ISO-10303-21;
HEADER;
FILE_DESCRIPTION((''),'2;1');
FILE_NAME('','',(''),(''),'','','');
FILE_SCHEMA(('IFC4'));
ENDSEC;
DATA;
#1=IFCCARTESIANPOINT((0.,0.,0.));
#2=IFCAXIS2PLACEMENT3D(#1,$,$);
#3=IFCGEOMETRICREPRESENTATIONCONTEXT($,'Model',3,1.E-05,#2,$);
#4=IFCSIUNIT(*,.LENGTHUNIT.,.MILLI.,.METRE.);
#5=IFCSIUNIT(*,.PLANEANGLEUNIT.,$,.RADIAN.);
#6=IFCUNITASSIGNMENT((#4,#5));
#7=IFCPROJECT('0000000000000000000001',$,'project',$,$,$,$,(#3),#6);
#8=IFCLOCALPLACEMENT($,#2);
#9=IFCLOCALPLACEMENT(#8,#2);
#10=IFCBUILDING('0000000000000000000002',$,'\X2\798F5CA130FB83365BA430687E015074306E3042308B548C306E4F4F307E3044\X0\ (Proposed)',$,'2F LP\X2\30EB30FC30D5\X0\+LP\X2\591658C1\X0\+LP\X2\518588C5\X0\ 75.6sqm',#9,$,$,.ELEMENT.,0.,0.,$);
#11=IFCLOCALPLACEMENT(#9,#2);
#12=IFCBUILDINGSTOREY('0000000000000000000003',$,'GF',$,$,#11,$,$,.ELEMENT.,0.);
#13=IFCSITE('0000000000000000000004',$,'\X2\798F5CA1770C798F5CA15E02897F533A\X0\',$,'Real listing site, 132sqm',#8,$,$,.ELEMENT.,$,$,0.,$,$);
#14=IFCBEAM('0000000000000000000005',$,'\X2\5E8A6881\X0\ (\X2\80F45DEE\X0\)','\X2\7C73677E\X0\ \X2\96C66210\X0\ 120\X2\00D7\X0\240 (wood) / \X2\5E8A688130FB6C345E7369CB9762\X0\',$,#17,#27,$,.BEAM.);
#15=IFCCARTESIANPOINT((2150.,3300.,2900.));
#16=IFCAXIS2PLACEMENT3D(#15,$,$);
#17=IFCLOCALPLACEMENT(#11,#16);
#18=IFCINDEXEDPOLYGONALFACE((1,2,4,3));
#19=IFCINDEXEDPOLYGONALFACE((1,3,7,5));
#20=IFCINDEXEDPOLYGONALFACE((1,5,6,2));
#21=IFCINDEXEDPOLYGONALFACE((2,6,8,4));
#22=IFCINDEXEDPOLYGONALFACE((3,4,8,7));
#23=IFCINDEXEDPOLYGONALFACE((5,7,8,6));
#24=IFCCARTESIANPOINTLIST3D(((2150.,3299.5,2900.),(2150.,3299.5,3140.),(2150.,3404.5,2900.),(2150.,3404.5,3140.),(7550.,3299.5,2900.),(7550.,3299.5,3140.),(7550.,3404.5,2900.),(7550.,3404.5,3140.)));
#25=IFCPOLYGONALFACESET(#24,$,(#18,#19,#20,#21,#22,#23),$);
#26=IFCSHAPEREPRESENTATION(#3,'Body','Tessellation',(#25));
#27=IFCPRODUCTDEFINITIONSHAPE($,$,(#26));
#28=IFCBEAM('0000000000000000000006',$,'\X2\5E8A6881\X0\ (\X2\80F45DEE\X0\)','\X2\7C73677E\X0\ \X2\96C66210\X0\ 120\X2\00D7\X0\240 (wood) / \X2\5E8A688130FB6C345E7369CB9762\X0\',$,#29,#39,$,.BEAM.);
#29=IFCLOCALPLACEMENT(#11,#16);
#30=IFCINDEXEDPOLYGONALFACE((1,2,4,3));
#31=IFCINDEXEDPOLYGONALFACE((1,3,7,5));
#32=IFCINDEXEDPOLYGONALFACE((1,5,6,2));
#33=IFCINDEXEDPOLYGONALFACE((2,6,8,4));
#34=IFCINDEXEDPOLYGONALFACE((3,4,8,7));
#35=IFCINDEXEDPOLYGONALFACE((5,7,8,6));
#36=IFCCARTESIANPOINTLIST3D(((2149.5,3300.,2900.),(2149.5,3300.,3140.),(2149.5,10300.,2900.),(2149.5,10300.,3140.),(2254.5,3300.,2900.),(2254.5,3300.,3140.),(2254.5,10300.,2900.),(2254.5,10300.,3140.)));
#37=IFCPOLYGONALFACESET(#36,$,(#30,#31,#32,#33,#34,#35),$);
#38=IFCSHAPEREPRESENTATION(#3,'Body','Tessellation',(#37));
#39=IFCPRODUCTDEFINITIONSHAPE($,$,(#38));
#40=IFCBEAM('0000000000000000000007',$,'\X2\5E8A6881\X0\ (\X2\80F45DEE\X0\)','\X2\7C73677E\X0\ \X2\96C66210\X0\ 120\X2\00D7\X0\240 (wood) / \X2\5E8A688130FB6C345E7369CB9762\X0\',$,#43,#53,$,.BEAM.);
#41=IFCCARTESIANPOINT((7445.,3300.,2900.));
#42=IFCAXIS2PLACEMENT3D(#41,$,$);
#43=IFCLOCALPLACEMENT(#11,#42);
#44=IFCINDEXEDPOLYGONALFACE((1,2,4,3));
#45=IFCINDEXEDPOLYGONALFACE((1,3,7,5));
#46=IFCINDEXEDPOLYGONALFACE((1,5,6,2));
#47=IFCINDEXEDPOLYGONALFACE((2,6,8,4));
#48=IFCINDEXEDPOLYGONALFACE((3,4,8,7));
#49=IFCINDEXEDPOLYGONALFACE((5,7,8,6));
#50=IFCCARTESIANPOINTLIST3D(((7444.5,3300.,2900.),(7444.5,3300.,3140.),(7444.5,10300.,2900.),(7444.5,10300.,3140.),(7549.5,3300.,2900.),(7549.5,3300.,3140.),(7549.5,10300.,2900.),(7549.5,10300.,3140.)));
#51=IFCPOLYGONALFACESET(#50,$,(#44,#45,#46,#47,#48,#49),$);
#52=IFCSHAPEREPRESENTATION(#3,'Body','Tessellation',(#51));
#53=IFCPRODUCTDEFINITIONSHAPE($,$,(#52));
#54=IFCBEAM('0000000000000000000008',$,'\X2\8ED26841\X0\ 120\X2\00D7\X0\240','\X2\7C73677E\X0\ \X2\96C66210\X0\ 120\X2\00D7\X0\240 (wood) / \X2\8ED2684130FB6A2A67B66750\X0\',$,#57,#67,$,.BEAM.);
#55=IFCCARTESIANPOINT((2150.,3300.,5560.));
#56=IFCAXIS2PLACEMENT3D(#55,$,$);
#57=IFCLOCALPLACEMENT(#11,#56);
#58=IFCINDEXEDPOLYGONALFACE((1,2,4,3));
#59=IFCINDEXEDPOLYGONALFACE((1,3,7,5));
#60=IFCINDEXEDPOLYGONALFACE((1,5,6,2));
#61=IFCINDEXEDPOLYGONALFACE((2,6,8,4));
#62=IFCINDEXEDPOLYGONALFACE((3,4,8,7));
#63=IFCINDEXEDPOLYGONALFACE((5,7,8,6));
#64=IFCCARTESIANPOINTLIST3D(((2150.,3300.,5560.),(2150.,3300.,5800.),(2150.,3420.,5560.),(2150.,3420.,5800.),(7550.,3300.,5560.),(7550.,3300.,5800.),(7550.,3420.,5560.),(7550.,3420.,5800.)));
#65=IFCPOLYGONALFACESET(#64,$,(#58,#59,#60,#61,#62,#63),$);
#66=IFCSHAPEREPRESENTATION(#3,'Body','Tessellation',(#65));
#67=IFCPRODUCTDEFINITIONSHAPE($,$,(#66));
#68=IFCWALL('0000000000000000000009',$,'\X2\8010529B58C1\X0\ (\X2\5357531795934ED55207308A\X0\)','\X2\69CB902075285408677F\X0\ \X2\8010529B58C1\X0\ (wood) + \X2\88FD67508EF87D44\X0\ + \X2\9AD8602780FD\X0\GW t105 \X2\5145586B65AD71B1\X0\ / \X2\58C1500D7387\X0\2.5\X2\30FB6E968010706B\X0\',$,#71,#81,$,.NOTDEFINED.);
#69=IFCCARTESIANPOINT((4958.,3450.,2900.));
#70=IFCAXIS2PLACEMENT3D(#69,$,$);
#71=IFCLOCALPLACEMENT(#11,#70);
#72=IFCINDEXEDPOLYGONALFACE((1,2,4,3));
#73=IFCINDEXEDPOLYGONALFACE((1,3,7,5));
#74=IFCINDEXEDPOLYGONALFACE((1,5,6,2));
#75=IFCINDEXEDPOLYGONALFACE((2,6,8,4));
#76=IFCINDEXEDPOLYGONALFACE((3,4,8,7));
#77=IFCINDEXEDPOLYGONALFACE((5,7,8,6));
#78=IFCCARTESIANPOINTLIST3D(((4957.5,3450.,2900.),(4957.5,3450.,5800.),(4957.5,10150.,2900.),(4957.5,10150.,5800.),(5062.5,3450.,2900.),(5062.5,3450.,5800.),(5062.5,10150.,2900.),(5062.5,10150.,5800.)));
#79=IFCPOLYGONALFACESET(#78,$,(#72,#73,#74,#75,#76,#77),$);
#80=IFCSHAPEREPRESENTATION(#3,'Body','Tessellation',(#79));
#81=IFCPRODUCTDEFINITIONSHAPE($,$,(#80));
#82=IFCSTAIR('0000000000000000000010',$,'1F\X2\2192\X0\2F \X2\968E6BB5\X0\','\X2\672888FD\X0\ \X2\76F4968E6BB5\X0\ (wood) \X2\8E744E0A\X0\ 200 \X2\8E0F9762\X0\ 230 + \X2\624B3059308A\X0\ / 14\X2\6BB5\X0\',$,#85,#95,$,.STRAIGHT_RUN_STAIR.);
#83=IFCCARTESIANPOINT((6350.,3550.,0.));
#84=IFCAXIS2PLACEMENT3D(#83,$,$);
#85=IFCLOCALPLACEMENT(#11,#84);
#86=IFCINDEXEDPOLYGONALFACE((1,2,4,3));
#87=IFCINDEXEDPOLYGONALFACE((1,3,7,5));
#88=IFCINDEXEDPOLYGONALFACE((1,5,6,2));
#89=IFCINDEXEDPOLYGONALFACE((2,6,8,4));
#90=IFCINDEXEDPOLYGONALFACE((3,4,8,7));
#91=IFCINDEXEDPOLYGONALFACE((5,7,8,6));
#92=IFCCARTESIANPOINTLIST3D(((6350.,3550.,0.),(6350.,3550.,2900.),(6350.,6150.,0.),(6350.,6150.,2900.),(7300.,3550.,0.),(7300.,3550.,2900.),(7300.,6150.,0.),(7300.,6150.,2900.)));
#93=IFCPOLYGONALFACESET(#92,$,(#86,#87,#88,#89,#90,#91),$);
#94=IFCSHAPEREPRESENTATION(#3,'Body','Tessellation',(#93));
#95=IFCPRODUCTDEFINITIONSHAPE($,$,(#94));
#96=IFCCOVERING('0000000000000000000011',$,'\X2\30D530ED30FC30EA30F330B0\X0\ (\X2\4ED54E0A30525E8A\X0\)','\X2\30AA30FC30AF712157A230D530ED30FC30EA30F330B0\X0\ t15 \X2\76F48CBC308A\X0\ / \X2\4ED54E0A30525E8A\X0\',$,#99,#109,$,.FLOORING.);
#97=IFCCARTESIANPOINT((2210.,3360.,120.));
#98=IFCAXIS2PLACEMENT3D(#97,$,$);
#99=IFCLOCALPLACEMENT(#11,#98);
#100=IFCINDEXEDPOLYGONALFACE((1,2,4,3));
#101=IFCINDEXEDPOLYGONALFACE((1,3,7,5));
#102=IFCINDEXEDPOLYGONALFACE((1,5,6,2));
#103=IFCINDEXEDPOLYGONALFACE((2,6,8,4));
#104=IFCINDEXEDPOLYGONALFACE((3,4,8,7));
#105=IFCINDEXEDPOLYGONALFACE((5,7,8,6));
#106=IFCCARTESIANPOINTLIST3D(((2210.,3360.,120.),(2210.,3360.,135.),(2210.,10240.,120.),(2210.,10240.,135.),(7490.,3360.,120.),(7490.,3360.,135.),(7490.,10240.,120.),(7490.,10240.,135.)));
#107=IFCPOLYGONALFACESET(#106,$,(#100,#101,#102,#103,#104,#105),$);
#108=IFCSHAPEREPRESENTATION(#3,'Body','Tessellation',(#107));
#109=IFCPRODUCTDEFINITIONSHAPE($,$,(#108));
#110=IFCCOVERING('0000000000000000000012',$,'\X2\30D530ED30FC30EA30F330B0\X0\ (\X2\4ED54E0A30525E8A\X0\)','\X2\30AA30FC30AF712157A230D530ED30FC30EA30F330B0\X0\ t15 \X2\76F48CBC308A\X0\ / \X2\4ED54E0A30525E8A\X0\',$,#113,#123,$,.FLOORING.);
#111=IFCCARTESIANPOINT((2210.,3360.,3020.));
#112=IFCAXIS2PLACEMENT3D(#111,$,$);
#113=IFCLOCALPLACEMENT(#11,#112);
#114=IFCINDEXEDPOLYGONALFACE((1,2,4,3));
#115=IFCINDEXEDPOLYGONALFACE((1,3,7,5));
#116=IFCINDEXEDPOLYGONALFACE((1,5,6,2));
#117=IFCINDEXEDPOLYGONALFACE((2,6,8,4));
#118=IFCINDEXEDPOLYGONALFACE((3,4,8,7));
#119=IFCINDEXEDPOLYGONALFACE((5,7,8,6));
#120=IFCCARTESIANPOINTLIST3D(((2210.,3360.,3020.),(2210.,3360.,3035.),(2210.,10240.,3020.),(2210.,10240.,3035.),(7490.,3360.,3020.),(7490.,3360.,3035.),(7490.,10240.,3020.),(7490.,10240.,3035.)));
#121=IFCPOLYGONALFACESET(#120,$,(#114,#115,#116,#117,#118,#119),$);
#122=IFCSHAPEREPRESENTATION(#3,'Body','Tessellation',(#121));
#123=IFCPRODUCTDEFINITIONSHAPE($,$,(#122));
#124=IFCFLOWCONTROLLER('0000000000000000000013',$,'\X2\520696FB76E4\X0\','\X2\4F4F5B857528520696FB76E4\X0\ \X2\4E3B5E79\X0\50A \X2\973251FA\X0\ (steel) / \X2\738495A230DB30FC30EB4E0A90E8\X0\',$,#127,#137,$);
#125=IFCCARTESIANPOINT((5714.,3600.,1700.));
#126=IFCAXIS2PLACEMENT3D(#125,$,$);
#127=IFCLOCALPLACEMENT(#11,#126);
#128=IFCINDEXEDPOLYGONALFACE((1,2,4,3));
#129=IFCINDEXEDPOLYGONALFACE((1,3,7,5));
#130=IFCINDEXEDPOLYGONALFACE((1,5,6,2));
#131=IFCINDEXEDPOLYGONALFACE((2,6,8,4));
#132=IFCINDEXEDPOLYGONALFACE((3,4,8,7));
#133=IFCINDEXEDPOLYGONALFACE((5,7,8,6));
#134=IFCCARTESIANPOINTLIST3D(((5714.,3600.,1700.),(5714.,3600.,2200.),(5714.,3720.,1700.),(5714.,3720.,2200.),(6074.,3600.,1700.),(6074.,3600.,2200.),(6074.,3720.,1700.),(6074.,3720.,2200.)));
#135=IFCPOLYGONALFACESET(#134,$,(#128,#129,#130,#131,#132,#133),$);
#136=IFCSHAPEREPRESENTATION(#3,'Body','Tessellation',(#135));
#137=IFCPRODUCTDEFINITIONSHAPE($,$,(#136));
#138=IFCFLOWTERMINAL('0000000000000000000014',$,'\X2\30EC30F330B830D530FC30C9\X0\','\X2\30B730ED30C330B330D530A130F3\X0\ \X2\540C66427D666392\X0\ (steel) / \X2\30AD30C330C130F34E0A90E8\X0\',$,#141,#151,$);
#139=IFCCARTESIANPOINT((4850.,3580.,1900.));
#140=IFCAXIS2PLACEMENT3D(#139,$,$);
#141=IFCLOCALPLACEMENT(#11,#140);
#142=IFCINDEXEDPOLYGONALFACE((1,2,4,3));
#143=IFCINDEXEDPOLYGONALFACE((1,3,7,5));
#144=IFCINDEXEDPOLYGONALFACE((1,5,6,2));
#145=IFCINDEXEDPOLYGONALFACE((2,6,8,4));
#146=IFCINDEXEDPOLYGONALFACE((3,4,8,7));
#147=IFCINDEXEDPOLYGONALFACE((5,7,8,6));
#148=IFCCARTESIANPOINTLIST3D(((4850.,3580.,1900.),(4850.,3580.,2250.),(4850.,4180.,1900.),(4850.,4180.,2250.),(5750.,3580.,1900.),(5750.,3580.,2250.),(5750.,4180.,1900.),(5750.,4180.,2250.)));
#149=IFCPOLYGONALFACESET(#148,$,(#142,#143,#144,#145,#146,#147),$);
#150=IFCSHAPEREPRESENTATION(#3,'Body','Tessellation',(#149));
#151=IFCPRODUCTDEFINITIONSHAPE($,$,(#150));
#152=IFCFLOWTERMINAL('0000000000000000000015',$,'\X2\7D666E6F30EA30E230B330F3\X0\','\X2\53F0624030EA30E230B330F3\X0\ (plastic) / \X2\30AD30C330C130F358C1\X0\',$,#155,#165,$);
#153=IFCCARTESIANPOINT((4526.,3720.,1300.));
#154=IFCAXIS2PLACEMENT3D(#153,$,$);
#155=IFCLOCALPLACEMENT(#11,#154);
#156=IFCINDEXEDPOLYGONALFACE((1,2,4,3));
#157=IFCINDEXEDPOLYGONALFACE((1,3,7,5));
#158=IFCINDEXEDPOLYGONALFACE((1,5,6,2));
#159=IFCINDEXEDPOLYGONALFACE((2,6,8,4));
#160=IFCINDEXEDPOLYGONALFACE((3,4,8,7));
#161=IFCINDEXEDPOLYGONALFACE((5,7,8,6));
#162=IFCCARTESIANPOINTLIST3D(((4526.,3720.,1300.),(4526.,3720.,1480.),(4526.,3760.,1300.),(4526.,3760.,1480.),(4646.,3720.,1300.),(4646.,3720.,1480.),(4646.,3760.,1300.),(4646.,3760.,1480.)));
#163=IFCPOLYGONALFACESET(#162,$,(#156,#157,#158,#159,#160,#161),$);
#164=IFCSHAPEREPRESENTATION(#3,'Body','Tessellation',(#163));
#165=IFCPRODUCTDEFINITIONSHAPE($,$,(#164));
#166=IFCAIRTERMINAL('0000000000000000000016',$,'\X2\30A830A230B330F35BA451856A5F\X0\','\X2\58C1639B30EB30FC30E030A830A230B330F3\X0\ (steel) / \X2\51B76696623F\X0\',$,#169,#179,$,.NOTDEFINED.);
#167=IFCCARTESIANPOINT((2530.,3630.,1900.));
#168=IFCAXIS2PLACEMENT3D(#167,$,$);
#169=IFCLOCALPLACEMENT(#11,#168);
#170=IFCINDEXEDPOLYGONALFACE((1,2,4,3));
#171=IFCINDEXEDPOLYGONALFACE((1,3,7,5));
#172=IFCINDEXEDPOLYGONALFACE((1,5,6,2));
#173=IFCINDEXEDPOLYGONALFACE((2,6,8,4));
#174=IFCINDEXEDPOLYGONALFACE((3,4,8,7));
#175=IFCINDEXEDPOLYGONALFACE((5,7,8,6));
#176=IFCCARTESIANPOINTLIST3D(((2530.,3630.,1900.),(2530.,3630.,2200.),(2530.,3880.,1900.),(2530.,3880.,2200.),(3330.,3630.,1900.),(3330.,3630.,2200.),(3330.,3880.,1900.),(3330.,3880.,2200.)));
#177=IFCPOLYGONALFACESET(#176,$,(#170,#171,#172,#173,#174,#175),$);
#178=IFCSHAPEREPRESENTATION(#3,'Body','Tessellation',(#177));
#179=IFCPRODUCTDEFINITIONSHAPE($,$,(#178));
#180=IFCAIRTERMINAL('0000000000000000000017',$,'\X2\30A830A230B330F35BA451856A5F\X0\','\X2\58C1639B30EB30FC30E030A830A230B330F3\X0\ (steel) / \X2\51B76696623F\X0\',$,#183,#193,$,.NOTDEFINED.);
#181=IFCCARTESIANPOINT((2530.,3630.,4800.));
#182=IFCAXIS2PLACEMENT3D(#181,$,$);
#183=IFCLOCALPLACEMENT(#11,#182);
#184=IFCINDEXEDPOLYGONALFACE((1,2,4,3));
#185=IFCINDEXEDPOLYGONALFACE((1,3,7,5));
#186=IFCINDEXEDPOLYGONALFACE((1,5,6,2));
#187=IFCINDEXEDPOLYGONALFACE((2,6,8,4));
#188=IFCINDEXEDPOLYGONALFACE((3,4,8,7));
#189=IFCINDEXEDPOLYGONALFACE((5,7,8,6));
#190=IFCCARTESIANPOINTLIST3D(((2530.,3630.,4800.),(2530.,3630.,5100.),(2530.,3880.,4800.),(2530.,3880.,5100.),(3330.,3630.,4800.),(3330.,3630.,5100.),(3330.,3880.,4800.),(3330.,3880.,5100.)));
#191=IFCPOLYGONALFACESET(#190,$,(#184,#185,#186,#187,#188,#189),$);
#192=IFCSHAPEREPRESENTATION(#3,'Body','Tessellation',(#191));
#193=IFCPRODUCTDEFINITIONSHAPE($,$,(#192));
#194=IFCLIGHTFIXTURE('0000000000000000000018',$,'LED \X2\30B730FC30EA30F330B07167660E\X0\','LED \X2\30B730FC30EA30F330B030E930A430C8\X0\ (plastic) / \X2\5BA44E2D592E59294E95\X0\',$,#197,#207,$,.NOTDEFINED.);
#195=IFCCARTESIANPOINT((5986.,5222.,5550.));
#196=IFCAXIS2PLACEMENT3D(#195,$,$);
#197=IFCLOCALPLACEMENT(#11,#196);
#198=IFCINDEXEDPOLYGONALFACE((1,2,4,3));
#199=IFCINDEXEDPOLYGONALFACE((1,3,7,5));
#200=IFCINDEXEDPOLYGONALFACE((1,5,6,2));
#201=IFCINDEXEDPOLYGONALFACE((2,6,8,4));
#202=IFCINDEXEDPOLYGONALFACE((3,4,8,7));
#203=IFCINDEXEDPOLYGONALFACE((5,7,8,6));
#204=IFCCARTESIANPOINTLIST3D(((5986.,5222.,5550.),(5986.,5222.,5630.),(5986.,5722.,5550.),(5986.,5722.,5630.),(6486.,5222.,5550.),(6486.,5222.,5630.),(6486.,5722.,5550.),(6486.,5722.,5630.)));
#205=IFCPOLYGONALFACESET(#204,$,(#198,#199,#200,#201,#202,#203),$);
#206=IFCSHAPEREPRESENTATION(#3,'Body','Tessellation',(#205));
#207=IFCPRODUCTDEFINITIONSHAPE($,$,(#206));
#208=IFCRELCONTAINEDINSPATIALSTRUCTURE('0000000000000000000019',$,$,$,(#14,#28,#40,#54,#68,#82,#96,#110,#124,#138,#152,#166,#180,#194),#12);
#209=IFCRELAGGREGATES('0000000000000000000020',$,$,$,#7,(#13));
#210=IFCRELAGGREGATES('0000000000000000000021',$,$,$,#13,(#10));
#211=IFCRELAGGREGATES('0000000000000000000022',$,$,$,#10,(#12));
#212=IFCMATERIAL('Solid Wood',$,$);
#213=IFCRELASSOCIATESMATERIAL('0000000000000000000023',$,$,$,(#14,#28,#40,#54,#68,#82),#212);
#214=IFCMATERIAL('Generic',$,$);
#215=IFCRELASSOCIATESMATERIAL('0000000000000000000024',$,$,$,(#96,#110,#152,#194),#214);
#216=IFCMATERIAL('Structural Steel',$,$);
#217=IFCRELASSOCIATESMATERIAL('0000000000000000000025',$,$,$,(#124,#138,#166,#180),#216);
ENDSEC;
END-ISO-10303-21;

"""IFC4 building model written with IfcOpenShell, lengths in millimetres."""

from ifc_helpers import new_model, si_unit, frame, frame_2d, origin, place, context, project, spatial, rectangle, extrude, material, element, save


model = new_model("IFC4")

# Units and contexts
model_context = context("Model", 3, precision=1e-05, world=origin())
ifc_project = project(units=[si_unit("LENGTHUNIT", "METRE", prefix="MILLI"), si_unit("PLANEANGLEUNIT", "RADIAN")], contexts=[model_context])

# Site, building, storey
site_placement = place(None, origin())
site = spatial("IfcSite", under=ifc_project, at=site_placement, Name="福岡県福岡市西区", ObjectType="Real listing site, 132sqm", CompositionType="ELEMENT", RefElevation=0.0)
building_placement = place(site_placement, origin())
building = spatial("IfcBuilding", under=site, at=building_placement, Name="福岡・茶室と縁側のある和の住まい (Proposed)", ObjectType="2F LPルーフ+LP外壁+LP内装 75.6sqm", CompositionType="ELEMENT", ElevationOfRefHeight=0.0, ElevationOfTerrain=0.0)
storey_placement = place(building_placement, origin())
storey = spatial("IfcBuildingStorey", under=building, at=storey_placement, Name="GF", CompositionType="ELEMENT", Elevation=0.0)

# Shared definitions
ifc_material_1 = material(Name="Solid Wood")

# Beams
beam_1_placement = place(storey_placement, frame((2150.0, 3300.0, 2900.0)))
element("IfcBeam", 1, at=beam_1_placement, inside=storey, material=ifc_material_1, Name="床梁 (胴差)", Description="米松 集成 120×240 (wood) / 床梁・水平構面", PredefinedType="BEAM", context=model_context, shape_type="SweptSolid", body=[
    extrude(rectangle(XDim=5400.0, YDim=105.0, at=frame_2d((2700.0, 52.0))), frame((2150.0, 3300.0, 2900.0)), (0.0, 0.0, 1.0), 240.0),
])
beam_2_placement = place(storey_placement, frame((2150.0, 3300.0, 2900.0)))
element("IfcBeam", 2, at=beam_2_placement, inside=storey, material=ifc_material_1, Name="床梁 (胴差)", Description="米松 集成 120×240 (wood) / 床梁・水平構面", PredefinedType="BEAM", context=model_context, shape_type="SweptSolid", body=[
    extrude(rectangle(XDim=105.0, YDim=7000.0, at=frame_2d((52.0, 3500.0))), frame((2150.0, 3300.0, 2900.0)), (0.0, 0.0, 1.0), 240.0),
])
beam_3_placement = place(storey_placement, frame((7445.0, 3300.0, 2900.0)))
element("IfcBeam", 3, at=beam_3_placement, inside=storey, material=ifc_material_1, Name="床梁 (胴差)", Description="米松 集成 120×240 (wood) / 床梁・水平構面", PredefinedType="BEAM", context=model_context, shape_type="SweptSolid", body=[
    extrude(rectangle(XDim=105.0, YDim=7000.0, at=frame_2d((52.0, 3500.0))), frame((7445.0, 3300.0, 2900.0)), (0.0, 0.0, 1.0), 240.0),
])
beam_4_placement = place(storey_placement, frame((2150.0, 3300.0, 5560.0)))
element("IfcBeam", 4, at=beam_4_placement, inside=storey, material=ifc_material_1, Name="軒桁 120×240", Description="米松 集成 120×240 (wood) / 軒桁・横架材", PredefinedType="BEAM", context=model_context, shape_type="SweptSolid", body=[
    extrude(rectangle(XDim=5400.0, YDim=120.0, at=frame_2d((2700.0, 60.0))), frame((2150.0, 3300.0, 5560.0)), (0.0, 0.0, 1.0), 240.0),
])

# Wall
wall_1_placement = place(storey_placement, frame((4958.0, 3450.0, 2900.0)))
element("IfcWall", 5, at=wall_1_placement, inside=storey, material=ifc_material_1, Name="耐力壁 (南北間仕切り)", Description="構造用合板 耐力壁 (wood) + 製材軸組 + 高性能GW t105 充填断熱 / 壁倍率2.5・準耐火", PredefinedType="NOTDEFINED", context=model_context, shape_type="SweptSolid", body=[
    extrude(rectangle(XDim=105.0, YDim=6700.0, at=frame_2d((52.0, 3350.0))), frame((4958.0, 3450.0, 2900.0)), (0.0, 0.0, 1.0), 2900.0),
])

# Stair
stair_placement = place(storey_placement, frame((6350.0, 3550.0, 0.0)))
element("IfcStair", 6, at=stair_placement, inside=storey, material=ifc_material_1, Name="1F→2F 階段", Description="木製 直階段 (wood) 蹴上 200 踏面 230 + 手すり / 14段", PredefinedType="STRAIGHT_RUN_STAIR", context=model_context, shape_type="SweptSolid", body=[
    extrude(rectangle(XDim=950.0, YDim=2600.0, at=frame_2d((475.0, 1300.0))), frame((6350.0, 3550.0, 0.0)), (0.0, 0.0, 1.0), 2900.0),
])

# Coverings
ifc_material_2 = material(Name="Generic")
covering_1_placement = place(storey_placement, frame((2210.0, 3360.0, 120.0)))
element("IfcCovering", 7, at=covering_1_placement, inside=storey, material=ifc_material_2, Name="フローリング (仕上げ床)", Description="オーク無垢フローリング t15 直貼り / 仕上げ床", PredefinedType="FLOORING", context=model_context, shape_type="SweptSolid", body=[
    extrude(rectangle(XDim=5280.0, YDim=6880.0, at=frame_2d((2640.0, 3440.0))), frame((2210.0, 3360.0, 120.0)), (0.0, 0.0, 1.0), 15.0),
])
covering_2_placement = place(storey_placement, frame((2210.0, 3360.0, 3020.0)))
element("IfcCovering", 8, at=covering_2_placement, inside=storey, material=ifc_material_2, Name="フローリング (仕上げ床)", Description="オーク無垢フローリング t15 直貼り / 仕上げ床", PredefinedType="FLOORING", context=model_context, shape_type="SweptSolid", body=[
    extrude(rectangle(XDim=5280.0, YDim=6880.0, at=frame_2d((2640.0, 3440.0))), frame((2210.0, 3360.0, 3020.0)), (0.0, 0.0, 1.0), 15.0),
])

# Flow controller
ifc_material_3 = material(Name="Structural Steel")
flow_controller_placement = place(storey_placement, frame((5714.0, 3600.0, 1700.0)))
element("IfcFlowController", 9, at=flow_controller_placement, inside=storey, material=ifc_material_3, Name="分電盤", Description="住宅用分電盤 主幹50A 露出 (steel) / 玄関ホール上部", context=model_context, shape_type="SweptSolid", body=[
    extrude(rectangle(XDim=360.0, YDim=120.0, at=frame_2d((180.0, 60.0))), frame((5714.0, 3600.0, 1700.0)), (0.0, 0.0, 1.0), 500.0),
])

# Flow terminals
flow_terminal_1_placement = place(storey_placement, frame((4850.0, 3580.0, 1900.0)))
element("IfcFlowTerminal", 10, at=flow_terminal_1_placement, inside=storey, material=ifc_material_3, Name="レンジフード", Description="シロッコファン 同時給排 (steel) / キッチン上部", context=model_context, shape_type="SweptSolid", body=[
    extrude(rectangle(XDim=900.0, YDim=600.0, at=frame_2d((450.0, 300.0))), frame((4850.0, 3580.0, 1900.0)), (0.0, 0.0, 1.0), 350.0),
])
flow_terminal_2_placement = place(storey_placement, frame((4526.0, 3720.0, 1300.0)))
element("IfcFlowTerminal", 11, at=flow_terminal_2_placement, inside=storey, material=ifc_material_2, Name="給湯リモコン", Description="台所リモコン (plastic) / キッチン壁", context=model_context, shape_type="SweptSolid", body=[
    extrude(rectangle(XDim=120.0, YDim=40.0, at=frame_2d((60.0, 20.0))), frame((4526.0, 3720.0, 1300.0)), (0.0, 0.0, 1.0), 180.0),
])

# Air terminals
air_terminal_1_placement = place(storey_placement, frame((2530.0, 3630.0, 1900.0)))
element("IfcAirTerminal", 12, at=air_terminal_1_placement, inside=storey, material=ifc_material_3, Name="エアコン室内機", Description="壁掛ルームエアコン (steel) / 冷暖房", PredefinedType="NOTDEFINED", context=model_context, shape_type="SweptSolid", body=[
    extrude(rectangle(XDim=800.0, YDim=250.0, at=frame_2d((400.0, 125.0))), frame((2530.0, 3630.0, 1900.0)), (0.0, 0.0, 1.0), 300.0),
])
air_terminal_2_placement = place(storey_placement, frame((2530.0, 3630.0, 4800.0)))
element("IfcAirTerminal", 13, at=air_terminal_2_placement, inside=storey, material=ifc_material_3, Name="エアコン室内機", Description="壁掛ルームエアコン (steel) / 冷暖房", PredefinedType="NOTDEFINED", context=model_context, shape_type="SweptSolid", body=[
    extrude(rectangle(XDim=800.0, YDim=250.0, at=frame_2d((400.0, 125.0))), frame((2530.0, 3630.0, 4800.0)), (0.0, 0.0, 1.0), 300.0),
])

# Light fixture
light_fixture_placement = place(storey_placement, frame((5986.0, 5222.0, 5550.0)))
element("IfcLightFixture", 14, at=light_fixture_placement, inside=storey, material=ifc_material_2, Name="LED シーリング照明", Description="LED シーリングライト (plastic) / 室中央天井", PredefinedType="NOTDEFINED", context=model_context, shape_type="SweptSolid", body=[
    extrude(rectangle(XDim=500.0, YDim=500.0, at=frame_2d((250.0, 250.0))), frame((5986.0, 5222.0, 5550.0)), (0.0, 0.0, 1.0), 80.0),
])

save(model, "model.ifc")
